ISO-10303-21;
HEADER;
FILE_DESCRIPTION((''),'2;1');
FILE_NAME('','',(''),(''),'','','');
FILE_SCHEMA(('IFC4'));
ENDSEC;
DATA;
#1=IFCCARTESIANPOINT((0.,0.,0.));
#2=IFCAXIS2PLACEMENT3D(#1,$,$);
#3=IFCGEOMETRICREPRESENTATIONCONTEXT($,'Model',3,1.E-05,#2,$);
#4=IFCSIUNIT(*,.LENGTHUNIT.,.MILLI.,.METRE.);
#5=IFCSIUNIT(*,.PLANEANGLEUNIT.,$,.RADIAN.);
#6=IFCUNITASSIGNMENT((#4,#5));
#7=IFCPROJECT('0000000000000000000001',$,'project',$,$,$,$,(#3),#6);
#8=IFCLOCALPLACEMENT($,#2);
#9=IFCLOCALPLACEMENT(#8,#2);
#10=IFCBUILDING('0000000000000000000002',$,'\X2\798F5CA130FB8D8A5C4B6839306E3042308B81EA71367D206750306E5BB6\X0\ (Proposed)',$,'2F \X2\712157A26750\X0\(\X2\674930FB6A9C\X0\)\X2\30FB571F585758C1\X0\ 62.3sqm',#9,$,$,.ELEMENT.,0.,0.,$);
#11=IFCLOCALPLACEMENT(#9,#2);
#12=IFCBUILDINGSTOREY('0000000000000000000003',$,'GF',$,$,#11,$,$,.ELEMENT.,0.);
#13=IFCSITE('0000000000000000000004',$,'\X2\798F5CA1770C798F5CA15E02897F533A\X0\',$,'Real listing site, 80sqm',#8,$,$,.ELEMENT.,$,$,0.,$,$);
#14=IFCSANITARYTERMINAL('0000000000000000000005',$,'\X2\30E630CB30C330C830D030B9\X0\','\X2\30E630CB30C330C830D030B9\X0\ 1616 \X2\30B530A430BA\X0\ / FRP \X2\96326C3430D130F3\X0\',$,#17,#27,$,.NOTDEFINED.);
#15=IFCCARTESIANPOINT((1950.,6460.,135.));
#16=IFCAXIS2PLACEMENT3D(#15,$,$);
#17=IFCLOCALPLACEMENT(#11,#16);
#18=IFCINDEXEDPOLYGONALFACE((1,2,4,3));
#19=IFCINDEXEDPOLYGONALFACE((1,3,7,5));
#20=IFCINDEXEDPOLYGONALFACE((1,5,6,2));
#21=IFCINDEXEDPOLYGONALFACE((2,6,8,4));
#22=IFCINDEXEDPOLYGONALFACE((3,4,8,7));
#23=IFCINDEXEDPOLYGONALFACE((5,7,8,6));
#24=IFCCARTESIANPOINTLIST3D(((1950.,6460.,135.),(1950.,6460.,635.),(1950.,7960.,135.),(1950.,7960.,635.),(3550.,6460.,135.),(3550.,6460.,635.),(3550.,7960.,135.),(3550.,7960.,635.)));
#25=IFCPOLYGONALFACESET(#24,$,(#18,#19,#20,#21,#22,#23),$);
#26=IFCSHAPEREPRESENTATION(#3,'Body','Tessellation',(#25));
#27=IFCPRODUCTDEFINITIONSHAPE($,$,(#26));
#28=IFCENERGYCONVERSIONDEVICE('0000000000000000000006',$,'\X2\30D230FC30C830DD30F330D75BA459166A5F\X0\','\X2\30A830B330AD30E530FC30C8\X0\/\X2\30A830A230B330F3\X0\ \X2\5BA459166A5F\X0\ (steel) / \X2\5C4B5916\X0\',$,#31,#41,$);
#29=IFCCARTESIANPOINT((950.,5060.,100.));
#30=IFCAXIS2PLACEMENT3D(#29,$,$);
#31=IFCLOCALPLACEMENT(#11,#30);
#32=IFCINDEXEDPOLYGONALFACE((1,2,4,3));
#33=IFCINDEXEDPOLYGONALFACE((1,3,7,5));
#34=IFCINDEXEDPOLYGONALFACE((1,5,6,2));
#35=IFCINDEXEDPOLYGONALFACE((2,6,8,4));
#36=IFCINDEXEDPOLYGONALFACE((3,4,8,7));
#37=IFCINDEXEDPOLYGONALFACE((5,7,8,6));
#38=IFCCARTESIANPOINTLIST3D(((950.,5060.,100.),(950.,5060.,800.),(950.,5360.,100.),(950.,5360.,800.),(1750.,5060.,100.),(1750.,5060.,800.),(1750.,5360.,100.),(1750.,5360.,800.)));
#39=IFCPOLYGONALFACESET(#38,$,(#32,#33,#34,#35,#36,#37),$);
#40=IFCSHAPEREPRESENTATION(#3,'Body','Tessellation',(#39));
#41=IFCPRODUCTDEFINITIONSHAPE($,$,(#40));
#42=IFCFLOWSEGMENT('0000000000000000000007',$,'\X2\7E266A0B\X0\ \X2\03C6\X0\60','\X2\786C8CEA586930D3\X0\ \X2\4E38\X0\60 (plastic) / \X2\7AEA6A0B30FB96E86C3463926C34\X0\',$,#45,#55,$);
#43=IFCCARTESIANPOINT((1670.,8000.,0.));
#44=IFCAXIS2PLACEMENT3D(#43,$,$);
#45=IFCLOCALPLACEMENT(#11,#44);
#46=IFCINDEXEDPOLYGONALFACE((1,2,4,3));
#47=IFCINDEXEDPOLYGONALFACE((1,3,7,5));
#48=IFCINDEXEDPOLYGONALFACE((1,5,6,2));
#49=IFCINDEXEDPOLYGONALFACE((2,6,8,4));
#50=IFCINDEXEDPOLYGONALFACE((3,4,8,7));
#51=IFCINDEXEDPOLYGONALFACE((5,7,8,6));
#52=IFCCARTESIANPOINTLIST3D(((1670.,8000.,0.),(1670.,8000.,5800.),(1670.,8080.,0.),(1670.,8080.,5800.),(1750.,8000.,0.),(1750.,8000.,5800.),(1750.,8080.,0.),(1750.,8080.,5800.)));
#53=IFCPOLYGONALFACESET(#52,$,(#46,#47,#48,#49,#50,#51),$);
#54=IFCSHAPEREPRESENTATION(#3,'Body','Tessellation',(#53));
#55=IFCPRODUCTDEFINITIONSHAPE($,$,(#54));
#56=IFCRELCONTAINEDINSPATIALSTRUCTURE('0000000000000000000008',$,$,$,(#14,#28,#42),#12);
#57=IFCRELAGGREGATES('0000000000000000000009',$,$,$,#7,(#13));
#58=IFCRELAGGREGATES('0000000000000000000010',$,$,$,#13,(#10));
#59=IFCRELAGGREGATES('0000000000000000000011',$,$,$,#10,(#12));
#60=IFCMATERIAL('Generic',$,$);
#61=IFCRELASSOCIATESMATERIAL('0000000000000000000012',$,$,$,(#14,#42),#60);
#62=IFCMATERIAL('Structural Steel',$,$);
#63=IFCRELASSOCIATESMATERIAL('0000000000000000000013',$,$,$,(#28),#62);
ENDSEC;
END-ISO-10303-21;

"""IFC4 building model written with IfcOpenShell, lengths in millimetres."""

from ifc_helpers import new_model, si_unit, frame, frame_2d, origin, place, context, project, spatial, rectangle, extrude, material, element, save


model = new_model("IFC4")

# Units and contexts
model_context = context("Model", 3, precision=1e-05, world=origin())
ifc_project = project(units=[si_unit("LENGTHUNIT", "METRE", prefix="MILLI"), si_unit("PLANEANGLEUNIT", "RADIAN")], contexts=[model_context])

# Site, building, storey
site_placement = place(None, origin())
site = spatial("IfcSite", under=ifc_project, at=site_placement, Name="福岡県福岡市西区", ObjectType="Real listing site, 80sqm", CompositionType="ELEMENT", RefElevation=0.0)
building_placement = place(site_placement, origin())
building = spatial("IfcBuilding", under=site, at=building_placement, Name="福岡・越屋根のある自然素材の家 (Proposed)", ObjectType="2F 無垢材(杉・檜)・土塗壁 62.3sqm", CompositionType="ELEMENT", ElevationOfRefHeight=0.0, ElevationOfTerrain=0.0)
storey_placement = place(building_placement, origin())
storey = spatial("IfcBuildingStorey", under=building, at=storey_placement, Name="GF", CompositionType="ELEMENT", Elevation=0.0)

# Shared definitions
ifc_material_1 = material(Name="Generic")

# Sanitary terminal
sanitary_terminal_placement = place(storey_placement, frame((1950.0, 6460.0, 135.0)))
element("IfcSanitaryTerminal", 1, at=sanitary_terminal_placement, inside=storey, material=ifc_material_1, Name="ユニットバス", Description="ユニットバス 1616 サイズ / FRP 防水パン", PredefinedType="NOTDEFINED", context=model_context, shape_type="SweptSolid", body=[
    extrude(rectangle(XDim=1600.0, YDim=1500.0, at=frame_2d((800.0, 750.0))), frame((1950.0, 6460.0, 135.0)), (0.0, 0.0, 1.0), 500.0),
])

# Energy conversion device
ifc_material_2 = material(Name="Structural Steel")
energy_conversion_device_placement = place(storey_placement, frame((950.0, 5060.0, 100.0)))
element("IfcEnergyConversionDevice", 2, at=energy_conversion_device_placement, inside=storey, material=ifc_material_2, Name="ヒートポンプ室外機", Description="エコキュート/エアコン 室外機 (steel) / 屋外", context=model_context, shape_type="SweptSolid", body=[
    extrude(rectangle(XDim=800.0, YDim=300.0, at=frame_2d((400.0, 150.0))), frame((950.0, 5060.0, 100.0)), (0.0, 0.0, 1.0), 700.0),
])

# Flow segment
flow_segment_placement = place(storey_placement, frame((1670.0, 8000.0, 0.0)))
element("IfcFlowSegment", 3, at=flow_segment_placement, inside=storey, material=ifc_material_1, Name="縦樋 φ60", Description="硬質塩ビ 丸60 (plastic) / 竪樋・雨水排水", context=model_context, shape_type="SweptSolid", body=[
    extrude(rectangle(XDim=80.0, YDim=80.0, at=frame_2d((40.0, 40.0))), frame((1670.0, 8000.0, 0.0)), (0.0, 0.0, 1.0), 5800.0),
])

save(model, "model.ifc")
